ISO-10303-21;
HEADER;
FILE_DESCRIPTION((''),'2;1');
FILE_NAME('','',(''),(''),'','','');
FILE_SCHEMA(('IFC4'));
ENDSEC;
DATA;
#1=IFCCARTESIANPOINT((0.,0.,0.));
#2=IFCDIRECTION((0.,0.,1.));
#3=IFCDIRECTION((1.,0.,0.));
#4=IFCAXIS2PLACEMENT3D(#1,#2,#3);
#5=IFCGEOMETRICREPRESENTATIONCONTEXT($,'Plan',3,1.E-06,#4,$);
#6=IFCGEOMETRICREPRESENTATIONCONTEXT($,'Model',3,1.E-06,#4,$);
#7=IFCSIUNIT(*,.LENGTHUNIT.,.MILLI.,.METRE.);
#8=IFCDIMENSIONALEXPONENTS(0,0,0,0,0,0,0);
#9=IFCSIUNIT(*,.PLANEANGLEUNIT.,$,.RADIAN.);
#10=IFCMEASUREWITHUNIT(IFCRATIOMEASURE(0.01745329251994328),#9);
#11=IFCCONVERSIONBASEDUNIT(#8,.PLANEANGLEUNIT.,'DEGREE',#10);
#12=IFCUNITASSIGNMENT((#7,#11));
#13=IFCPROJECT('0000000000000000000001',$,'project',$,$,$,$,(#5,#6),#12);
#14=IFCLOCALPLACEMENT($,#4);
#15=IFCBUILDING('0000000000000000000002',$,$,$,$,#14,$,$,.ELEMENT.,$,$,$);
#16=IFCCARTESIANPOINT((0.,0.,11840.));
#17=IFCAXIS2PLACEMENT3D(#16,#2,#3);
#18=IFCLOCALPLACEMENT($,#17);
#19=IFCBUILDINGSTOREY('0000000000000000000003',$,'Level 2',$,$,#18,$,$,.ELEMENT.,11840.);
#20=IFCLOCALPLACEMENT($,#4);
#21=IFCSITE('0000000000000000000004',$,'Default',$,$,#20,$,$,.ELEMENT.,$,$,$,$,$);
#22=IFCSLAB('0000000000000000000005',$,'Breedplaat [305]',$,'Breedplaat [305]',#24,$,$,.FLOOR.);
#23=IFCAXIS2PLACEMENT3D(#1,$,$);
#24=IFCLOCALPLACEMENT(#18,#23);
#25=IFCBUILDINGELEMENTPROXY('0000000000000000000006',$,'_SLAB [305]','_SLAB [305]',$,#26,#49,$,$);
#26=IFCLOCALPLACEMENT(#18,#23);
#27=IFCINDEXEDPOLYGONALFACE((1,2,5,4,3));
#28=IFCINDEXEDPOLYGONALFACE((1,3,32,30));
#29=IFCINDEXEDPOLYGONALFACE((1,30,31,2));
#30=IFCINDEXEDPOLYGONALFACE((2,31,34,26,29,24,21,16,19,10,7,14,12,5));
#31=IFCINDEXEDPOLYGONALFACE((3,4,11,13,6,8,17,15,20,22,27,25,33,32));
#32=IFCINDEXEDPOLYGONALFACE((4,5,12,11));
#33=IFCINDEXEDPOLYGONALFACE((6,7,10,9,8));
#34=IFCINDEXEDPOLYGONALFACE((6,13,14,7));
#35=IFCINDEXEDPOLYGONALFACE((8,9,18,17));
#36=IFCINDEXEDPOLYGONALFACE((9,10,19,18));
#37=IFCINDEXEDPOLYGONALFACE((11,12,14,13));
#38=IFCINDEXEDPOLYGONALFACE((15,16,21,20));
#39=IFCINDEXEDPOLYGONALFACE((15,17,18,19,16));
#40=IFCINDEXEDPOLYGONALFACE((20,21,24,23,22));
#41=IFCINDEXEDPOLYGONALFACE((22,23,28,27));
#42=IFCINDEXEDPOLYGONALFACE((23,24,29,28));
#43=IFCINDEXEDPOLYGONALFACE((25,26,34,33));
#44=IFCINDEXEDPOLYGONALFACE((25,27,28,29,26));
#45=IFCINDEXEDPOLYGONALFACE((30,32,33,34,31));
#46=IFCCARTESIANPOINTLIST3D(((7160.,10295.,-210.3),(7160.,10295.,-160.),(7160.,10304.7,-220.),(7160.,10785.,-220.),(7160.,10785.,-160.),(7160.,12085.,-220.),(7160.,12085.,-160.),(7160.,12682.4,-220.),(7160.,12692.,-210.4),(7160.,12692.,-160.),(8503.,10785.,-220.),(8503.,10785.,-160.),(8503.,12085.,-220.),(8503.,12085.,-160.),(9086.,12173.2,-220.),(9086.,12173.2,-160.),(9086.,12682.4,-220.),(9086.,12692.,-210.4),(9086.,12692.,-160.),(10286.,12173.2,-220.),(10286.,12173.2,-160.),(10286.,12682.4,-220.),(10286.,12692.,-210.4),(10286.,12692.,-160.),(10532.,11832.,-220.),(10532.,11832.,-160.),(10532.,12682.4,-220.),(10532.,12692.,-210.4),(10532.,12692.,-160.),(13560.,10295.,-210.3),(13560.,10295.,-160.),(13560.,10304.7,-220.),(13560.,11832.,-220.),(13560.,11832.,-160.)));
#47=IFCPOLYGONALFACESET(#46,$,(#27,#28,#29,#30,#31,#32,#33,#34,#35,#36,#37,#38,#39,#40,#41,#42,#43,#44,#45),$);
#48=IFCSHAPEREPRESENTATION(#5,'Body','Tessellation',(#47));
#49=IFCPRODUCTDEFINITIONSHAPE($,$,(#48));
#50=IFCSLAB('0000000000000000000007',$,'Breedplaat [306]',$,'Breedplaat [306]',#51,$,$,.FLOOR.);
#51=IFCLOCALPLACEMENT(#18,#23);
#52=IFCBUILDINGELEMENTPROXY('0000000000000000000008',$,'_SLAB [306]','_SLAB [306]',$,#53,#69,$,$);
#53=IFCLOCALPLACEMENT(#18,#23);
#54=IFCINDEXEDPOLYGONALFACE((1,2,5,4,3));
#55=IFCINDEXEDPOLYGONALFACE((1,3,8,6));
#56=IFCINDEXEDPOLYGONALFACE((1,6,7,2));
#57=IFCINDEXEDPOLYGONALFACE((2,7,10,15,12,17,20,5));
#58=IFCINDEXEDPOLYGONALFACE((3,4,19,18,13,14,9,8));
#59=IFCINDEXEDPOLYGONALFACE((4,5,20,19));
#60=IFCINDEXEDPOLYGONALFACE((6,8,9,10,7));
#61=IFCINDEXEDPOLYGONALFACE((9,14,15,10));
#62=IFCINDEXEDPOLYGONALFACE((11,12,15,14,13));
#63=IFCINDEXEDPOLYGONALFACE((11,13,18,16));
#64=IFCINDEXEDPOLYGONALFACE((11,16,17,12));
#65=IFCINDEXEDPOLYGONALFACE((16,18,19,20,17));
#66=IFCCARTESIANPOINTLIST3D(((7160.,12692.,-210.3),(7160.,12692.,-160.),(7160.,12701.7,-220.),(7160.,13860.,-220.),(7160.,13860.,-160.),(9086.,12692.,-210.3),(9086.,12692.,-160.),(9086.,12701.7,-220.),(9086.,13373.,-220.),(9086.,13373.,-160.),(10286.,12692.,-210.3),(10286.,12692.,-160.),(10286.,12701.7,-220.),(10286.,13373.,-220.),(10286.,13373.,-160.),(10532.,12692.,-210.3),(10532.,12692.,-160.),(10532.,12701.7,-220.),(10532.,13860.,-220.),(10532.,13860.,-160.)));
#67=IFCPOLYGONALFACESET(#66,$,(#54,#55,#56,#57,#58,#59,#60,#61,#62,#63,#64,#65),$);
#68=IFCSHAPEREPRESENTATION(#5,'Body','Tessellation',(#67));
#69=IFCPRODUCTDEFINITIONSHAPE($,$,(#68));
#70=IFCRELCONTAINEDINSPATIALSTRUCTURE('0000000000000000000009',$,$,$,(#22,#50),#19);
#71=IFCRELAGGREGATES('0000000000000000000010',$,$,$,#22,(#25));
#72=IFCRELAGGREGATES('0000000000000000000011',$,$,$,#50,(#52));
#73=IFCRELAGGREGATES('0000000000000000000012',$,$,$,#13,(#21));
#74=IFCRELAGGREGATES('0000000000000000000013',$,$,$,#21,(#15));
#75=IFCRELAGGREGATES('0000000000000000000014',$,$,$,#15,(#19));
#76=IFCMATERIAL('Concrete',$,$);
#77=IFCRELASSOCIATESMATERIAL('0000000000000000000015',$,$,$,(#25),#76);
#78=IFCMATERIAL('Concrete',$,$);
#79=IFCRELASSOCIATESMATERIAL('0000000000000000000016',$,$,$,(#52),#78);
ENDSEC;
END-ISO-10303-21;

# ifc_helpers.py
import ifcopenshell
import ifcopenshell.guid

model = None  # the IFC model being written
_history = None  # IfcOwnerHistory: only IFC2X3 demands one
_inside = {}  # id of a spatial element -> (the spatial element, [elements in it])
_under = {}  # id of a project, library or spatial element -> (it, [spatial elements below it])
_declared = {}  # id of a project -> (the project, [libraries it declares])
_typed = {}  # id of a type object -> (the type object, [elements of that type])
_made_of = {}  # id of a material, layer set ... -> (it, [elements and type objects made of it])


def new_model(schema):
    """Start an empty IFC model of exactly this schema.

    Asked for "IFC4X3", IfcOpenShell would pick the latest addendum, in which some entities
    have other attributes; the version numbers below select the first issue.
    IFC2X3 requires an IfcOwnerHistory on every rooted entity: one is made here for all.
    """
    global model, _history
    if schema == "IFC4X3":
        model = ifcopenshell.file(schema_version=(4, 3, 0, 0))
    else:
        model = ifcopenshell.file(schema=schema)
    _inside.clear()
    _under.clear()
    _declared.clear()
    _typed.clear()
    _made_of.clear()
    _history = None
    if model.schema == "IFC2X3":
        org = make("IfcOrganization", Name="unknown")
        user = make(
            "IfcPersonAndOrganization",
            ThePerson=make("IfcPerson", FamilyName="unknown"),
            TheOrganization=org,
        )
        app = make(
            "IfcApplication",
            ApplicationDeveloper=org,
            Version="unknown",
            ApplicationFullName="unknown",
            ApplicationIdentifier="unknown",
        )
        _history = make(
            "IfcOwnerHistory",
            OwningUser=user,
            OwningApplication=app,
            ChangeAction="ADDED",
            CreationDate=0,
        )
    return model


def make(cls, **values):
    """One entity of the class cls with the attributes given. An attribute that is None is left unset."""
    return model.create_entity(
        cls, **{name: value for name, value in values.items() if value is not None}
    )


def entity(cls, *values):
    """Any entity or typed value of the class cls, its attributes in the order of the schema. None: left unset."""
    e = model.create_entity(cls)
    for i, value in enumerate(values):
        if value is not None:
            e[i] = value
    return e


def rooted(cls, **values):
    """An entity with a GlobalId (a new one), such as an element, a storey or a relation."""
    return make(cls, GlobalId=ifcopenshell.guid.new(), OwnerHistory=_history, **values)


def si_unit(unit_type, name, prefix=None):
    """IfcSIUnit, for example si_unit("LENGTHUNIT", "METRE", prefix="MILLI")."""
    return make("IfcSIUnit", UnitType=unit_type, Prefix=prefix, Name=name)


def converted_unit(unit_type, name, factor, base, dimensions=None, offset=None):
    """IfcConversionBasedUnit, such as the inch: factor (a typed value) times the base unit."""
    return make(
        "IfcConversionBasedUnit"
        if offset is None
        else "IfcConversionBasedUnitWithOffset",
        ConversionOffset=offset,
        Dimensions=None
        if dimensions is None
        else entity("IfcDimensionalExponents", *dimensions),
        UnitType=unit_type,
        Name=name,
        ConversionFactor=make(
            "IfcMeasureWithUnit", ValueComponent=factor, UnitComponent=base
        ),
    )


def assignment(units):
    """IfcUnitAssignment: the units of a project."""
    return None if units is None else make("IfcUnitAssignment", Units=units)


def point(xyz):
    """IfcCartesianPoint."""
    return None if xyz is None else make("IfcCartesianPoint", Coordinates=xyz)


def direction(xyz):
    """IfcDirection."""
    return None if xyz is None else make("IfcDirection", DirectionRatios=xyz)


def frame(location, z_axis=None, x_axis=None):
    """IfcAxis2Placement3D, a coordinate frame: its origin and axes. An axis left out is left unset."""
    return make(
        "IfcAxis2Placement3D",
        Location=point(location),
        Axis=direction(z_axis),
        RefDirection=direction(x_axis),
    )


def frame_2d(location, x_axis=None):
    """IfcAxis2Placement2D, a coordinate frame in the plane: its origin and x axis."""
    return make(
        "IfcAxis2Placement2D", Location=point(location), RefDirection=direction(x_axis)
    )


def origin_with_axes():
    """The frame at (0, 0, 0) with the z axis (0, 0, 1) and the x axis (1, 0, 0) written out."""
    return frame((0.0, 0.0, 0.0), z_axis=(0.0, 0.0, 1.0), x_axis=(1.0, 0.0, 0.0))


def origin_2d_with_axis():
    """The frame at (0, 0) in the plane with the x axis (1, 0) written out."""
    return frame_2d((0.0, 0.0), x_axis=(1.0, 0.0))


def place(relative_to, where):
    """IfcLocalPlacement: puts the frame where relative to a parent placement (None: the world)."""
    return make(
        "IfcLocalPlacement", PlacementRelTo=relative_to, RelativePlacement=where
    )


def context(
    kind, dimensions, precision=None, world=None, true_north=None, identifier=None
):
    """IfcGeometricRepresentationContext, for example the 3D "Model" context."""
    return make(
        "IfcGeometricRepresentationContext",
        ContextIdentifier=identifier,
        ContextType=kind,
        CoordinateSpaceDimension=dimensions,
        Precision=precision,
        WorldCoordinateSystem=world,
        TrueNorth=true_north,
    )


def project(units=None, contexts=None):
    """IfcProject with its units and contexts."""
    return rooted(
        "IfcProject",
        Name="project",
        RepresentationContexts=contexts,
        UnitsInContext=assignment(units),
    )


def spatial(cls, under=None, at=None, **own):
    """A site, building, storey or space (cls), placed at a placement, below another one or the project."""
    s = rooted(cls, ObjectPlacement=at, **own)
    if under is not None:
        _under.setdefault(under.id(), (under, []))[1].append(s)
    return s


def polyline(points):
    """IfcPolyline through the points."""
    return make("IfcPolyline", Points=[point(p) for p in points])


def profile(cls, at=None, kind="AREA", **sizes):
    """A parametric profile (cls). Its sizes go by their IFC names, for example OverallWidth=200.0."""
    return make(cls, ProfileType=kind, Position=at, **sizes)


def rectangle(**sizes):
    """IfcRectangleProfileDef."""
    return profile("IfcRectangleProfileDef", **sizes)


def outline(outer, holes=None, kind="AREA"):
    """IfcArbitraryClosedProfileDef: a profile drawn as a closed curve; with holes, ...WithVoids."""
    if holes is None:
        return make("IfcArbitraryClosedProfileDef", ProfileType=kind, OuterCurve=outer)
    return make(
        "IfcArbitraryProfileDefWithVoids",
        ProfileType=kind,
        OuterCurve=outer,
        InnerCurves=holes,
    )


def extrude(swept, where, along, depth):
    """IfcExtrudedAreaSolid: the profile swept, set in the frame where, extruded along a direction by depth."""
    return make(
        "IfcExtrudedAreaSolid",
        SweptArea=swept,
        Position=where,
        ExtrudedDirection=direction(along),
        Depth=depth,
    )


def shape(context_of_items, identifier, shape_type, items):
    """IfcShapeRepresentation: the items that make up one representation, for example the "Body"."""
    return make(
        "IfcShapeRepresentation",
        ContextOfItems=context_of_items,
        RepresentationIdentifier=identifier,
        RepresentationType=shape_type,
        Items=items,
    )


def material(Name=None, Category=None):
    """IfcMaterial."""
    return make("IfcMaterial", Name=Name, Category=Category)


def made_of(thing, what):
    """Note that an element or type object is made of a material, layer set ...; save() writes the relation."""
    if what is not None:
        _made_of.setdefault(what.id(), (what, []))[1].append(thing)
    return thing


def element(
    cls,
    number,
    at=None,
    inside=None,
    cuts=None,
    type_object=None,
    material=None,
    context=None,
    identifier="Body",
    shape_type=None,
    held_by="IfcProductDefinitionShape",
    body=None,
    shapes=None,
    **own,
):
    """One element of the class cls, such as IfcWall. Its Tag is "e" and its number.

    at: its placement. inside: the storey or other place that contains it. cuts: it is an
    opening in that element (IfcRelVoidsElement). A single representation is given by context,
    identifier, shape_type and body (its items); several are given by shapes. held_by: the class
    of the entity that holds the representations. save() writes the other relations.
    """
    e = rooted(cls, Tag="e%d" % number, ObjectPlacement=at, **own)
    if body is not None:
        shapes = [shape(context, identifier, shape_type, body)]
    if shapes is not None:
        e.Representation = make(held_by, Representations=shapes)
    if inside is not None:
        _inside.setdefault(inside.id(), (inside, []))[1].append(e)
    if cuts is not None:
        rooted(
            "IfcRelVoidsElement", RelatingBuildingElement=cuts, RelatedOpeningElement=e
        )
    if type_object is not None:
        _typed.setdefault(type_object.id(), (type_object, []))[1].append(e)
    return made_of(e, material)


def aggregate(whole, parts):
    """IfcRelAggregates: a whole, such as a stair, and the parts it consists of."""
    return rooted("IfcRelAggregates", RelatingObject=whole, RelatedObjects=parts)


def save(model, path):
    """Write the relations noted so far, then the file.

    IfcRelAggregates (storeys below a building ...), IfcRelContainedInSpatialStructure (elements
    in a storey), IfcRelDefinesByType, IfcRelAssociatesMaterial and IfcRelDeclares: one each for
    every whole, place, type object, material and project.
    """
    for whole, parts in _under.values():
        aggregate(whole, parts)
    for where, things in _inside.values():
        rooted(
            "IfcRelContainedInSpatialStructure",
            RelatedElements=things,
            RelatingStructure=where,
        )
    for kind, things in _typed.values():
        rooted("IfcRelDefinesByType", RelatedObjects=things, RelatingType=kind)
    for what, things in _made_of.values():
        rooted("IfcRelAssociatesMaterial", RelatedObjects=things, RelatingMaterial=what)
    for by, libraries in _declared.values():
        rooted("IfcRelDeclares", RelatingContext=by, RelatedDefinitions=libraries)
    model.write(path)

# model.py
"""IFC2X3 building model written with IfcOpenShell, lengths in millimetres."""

from ifc_helpers import new_model, entity, si_unit, converted_unit, frame, origin_with_axes, origin_2d_with_axis, place, context, project, spatial, polyline, rectangle, outline, extrude, material, element, aggregate, save


model = new_model("IFC2X3")

# Units and contexts
plan_context = context("Plan", 3, precision=1e-06, world=origin_with_axes())
model_context = context("Model", 3, precision=1e-06, world=origin_with_axes())
ifc_project = project(units=[si_unit("LENGTHUNIT", "METRE", prefix="MILLI"), converted_unit("PLANEANGLEUNIT", "DEGREE", entity("IfcRatioMeasure", 0.01745329251994328), si_unit("PLANEANGLEUNIT", "RADIAN"), dimensions=[0, 0, 0, 0, 0, 0, 0])], contexts=[plan_context, model_context])

# Site, building, storey
site_placement = place(None, origin_with_axes())
site = spatial("IfcSite", under=ifc_project, at=site_placement, Name="Default", CompositionType="ELEMENT")
building_placement = place(None, origin_with_axes())
building = spatial("IfcBuilding", under=site, at=building_placement, CompositionType="ELEMENT")
storey_placement = place(None, frame((0.0, 0.0, 11840.0), z_axis=(0.0, 0.0, 1.0), x_axis=(1.0, 0.0, 0.0)))
storey = spatial("IfcBuildingStorey", under=building, at=storey_placement, Name="Level 2", CompositionType="ELEMENT", Elevation=11840.0)

# Slabs, building element proxies, openings
slab_1_placement = place(None, frame((7160.0, 10295.0, 11620.0), z_axis=(0.0, 0.0, 1.0), x_axis=(1.0, 0.0, 0.0)))
slab_1 = element("IfcSlab", 1, at=slab_1_placement, inside=storey, Name="Breedplaat [305]", ObjectType="Breedplaat [305]", PredefinedType="FLOOR")
ifc_material_1 = material(Name="Concrete")
proxy_1_placement = place(slab_1_placement, origin_with_axes())
proxy_1 = element("IfcBuildingElementProxy", 2, at=proxy_1_placement, material=ifc_material_1, Name="_SLAB [305]", Description="_SLAB [305]", context=plan_context, shape_type="SweptSolid", body=[
    extrude(outline(polyline([(6400.0, 1537.0), (3372.0, 1537.0), (3372.0, 2397.0), (0.0, 2397.0), (0.0, 0.0), (6400.0, 0.0), (6400.0, 1537.0)])), origin_with_axes(), (0.0, 0.0, 1.0), 60.0),
])
opening_1_placement = place(slab_1_placement, frame((0.0, 490.0, 0.0), z_axis=(0.0, 0.0, 1.0), x_axis=(1.0, 0.0, 0.0)))
element("IfcOpeningElement", 3, at=opening_1_placement, cuts=proxy_1, ObjectType="Opening", context=plan_context, shape_type="SolidModel", body=[
    extrude(rectangle(XDim=1343.0, YDim=1300.0, at=origin_2d_with_axis()), frame((671.5, 650.0, 0.0), z_axis=(0.0, 0.0, 1.0), x_axis=(1.0, 0.0, 0.0)), (0.0, 0.0, 1.0), 60.0),
])
opening_2_placement = place(slab_1_placement, frame((1926.0, 1878.2, 0.0), z_axis=(0.0, 0.0, 1.0), x_axis=(1.0, 0.0, 0.0)))
element("IfcOpeningElement", 4, at=opening_2_placement, cuts=proxy_1, ObjectType="Opening", context=plan_context, shape_type="SolidModel", body=[
    extrude(rectangle(XDim=1200.0, YDim=519.0, at=origin_2d_with_axis()), frame((600.0, 259.5, 0.0), z_axis=(0.0, 0.0, 1.0), x_axis=(1.0, 0.0, 0.0)), (0.0, 0.0, 1.0), 60.0),
])
opening_3_placement = place(None, frame((7160.0, 10295.0, 11620.0), z_axis=(0.0, 0.0, 1.0), x_axis=(1.0, 0.0, 0.0)))
element("IfcOpeningElement", 5, at=opening_3_placement, cuts=proxy_1, ObjectType="Opening", context=plan_context, shape_type="SweptSolid", body=[
    extrude(outline(polyline([(-0.1, -0.1), (-0.1, 10.0), (10.0, -0.1), (-0.1, -0.1)])), frame((-1.2, -0.1, -0.1), z_axis=(1.0, 0.0, 0.0), x_axis=(0.0, 1.0, 0.0)), (0.0, 0.0, 1.0), 6402.2),
])
opening_4_placement = place(None, frame((7160.0, 10295.0, 11620.0), z_axis=(0.0, 0.0, 1.0), x_axis=(1.0, 0.0, 0.0)))
element("IfcOpeningElement", 6, at=opening_4_placement, cuts=proxy_1, ObjectType="Opening", context=plan_context, shape_type="SweptSolid", body=[
    extrude(outline(polyline([(-0.1, -0.1), (-0.1, 10.0), (10.0, -0.1), (-0.1, -0.1)])), frame((3373.2, 2397.2, -0.1), z_axis=(-1.0, 0.0, 0.0), x_axis=(0.0, -1.0, 0.0)), (0.0, 0.0, 1.0), 3374.2),
])
aggregate(slab_1, [proxy_1])
slab_2_placement = place(None, frame((7160.0, 12692.0, 11620.0), z_axis=(0.0, 0.0, 1.0), x_axis=(1.0, 0.0, 0.0)))
slab_2 = element("IfcSlab", 7, at=slab_2_placement, inside=storey, Name="Breedplaat [306]", ObjectType="Breedplaat [306]", PredefinedType="FLOOR")
ifc_material_2 = material(Name="Concrete")
proxy_2_placement = place(slab_2_placement, origin_with_axes())
proxy_2 = element("IfcBuildingElementProxy", 8, at=proxy_2_placement, material=ifc_material_2, Name="_SLAB [306]", Description="_SLAB [306]", context=plan_context, shape_type="SweptSolid", body=[
    extrude(outline(polyline([(0.0, 1168.0), (0.0, 0.0), (3372.0, 0.0), (3372.0, 1168.0), (0.0, 1168.0)])), origin_with_axes(), (0.0, 0.0, 1.0), 60.0),
])
opening_5_placement = place(slab_2_placement, frame((1926.0, 0.0, 0.0), z_axis=(0.0, 0.0, 1.0), x_axis=(1.0, 0.0, 0.0)))
element("IfcOpeningElement", 9, at=opening_5_placement, cuts=proxy_2, ObjectType="Opening", context=plan_context, shape_type="SolidModel", body=[
    extrude(rectangle(XDim=1200.0, YDim=681.0, at=origin_2d_with_axis()), frame((600.0, 340.5, 0.0), z_axis=(0.0, 0.0, 1.0), x_axis=(1.0, 0.0, 0.0)), (0.0, 0.0, 1.0), 60.0),
])
opening_6_placement = place(None, frame((7160.0, 12692.0, 11620.0), z_axis=(0.0, 0.0, 1.0), x_axis=(1.0, 0.0, 0.0)))
element("IfcOpeningElement", 10, at=opening_6_placement, cuts=proxy_2, ObjectType="Opening", context=plan_context, shape_type="SweptSolid", body=[
    extrude(outline(polyline([(-0.1, -0.1), (-0.1, 10.0), (10.0, -0.1), (-0.1, -0.1)])), frame((-1.2, -0.1, -0.1), z_axis=(1.0, 0.0, 0.0), x_axis=(0.0, 1.0, 0.0)), (0.0, 0.0, 1.0), 3374.2),
])
aggregate(slab_2, [proxy_2])

save(model, "model.ifc")
